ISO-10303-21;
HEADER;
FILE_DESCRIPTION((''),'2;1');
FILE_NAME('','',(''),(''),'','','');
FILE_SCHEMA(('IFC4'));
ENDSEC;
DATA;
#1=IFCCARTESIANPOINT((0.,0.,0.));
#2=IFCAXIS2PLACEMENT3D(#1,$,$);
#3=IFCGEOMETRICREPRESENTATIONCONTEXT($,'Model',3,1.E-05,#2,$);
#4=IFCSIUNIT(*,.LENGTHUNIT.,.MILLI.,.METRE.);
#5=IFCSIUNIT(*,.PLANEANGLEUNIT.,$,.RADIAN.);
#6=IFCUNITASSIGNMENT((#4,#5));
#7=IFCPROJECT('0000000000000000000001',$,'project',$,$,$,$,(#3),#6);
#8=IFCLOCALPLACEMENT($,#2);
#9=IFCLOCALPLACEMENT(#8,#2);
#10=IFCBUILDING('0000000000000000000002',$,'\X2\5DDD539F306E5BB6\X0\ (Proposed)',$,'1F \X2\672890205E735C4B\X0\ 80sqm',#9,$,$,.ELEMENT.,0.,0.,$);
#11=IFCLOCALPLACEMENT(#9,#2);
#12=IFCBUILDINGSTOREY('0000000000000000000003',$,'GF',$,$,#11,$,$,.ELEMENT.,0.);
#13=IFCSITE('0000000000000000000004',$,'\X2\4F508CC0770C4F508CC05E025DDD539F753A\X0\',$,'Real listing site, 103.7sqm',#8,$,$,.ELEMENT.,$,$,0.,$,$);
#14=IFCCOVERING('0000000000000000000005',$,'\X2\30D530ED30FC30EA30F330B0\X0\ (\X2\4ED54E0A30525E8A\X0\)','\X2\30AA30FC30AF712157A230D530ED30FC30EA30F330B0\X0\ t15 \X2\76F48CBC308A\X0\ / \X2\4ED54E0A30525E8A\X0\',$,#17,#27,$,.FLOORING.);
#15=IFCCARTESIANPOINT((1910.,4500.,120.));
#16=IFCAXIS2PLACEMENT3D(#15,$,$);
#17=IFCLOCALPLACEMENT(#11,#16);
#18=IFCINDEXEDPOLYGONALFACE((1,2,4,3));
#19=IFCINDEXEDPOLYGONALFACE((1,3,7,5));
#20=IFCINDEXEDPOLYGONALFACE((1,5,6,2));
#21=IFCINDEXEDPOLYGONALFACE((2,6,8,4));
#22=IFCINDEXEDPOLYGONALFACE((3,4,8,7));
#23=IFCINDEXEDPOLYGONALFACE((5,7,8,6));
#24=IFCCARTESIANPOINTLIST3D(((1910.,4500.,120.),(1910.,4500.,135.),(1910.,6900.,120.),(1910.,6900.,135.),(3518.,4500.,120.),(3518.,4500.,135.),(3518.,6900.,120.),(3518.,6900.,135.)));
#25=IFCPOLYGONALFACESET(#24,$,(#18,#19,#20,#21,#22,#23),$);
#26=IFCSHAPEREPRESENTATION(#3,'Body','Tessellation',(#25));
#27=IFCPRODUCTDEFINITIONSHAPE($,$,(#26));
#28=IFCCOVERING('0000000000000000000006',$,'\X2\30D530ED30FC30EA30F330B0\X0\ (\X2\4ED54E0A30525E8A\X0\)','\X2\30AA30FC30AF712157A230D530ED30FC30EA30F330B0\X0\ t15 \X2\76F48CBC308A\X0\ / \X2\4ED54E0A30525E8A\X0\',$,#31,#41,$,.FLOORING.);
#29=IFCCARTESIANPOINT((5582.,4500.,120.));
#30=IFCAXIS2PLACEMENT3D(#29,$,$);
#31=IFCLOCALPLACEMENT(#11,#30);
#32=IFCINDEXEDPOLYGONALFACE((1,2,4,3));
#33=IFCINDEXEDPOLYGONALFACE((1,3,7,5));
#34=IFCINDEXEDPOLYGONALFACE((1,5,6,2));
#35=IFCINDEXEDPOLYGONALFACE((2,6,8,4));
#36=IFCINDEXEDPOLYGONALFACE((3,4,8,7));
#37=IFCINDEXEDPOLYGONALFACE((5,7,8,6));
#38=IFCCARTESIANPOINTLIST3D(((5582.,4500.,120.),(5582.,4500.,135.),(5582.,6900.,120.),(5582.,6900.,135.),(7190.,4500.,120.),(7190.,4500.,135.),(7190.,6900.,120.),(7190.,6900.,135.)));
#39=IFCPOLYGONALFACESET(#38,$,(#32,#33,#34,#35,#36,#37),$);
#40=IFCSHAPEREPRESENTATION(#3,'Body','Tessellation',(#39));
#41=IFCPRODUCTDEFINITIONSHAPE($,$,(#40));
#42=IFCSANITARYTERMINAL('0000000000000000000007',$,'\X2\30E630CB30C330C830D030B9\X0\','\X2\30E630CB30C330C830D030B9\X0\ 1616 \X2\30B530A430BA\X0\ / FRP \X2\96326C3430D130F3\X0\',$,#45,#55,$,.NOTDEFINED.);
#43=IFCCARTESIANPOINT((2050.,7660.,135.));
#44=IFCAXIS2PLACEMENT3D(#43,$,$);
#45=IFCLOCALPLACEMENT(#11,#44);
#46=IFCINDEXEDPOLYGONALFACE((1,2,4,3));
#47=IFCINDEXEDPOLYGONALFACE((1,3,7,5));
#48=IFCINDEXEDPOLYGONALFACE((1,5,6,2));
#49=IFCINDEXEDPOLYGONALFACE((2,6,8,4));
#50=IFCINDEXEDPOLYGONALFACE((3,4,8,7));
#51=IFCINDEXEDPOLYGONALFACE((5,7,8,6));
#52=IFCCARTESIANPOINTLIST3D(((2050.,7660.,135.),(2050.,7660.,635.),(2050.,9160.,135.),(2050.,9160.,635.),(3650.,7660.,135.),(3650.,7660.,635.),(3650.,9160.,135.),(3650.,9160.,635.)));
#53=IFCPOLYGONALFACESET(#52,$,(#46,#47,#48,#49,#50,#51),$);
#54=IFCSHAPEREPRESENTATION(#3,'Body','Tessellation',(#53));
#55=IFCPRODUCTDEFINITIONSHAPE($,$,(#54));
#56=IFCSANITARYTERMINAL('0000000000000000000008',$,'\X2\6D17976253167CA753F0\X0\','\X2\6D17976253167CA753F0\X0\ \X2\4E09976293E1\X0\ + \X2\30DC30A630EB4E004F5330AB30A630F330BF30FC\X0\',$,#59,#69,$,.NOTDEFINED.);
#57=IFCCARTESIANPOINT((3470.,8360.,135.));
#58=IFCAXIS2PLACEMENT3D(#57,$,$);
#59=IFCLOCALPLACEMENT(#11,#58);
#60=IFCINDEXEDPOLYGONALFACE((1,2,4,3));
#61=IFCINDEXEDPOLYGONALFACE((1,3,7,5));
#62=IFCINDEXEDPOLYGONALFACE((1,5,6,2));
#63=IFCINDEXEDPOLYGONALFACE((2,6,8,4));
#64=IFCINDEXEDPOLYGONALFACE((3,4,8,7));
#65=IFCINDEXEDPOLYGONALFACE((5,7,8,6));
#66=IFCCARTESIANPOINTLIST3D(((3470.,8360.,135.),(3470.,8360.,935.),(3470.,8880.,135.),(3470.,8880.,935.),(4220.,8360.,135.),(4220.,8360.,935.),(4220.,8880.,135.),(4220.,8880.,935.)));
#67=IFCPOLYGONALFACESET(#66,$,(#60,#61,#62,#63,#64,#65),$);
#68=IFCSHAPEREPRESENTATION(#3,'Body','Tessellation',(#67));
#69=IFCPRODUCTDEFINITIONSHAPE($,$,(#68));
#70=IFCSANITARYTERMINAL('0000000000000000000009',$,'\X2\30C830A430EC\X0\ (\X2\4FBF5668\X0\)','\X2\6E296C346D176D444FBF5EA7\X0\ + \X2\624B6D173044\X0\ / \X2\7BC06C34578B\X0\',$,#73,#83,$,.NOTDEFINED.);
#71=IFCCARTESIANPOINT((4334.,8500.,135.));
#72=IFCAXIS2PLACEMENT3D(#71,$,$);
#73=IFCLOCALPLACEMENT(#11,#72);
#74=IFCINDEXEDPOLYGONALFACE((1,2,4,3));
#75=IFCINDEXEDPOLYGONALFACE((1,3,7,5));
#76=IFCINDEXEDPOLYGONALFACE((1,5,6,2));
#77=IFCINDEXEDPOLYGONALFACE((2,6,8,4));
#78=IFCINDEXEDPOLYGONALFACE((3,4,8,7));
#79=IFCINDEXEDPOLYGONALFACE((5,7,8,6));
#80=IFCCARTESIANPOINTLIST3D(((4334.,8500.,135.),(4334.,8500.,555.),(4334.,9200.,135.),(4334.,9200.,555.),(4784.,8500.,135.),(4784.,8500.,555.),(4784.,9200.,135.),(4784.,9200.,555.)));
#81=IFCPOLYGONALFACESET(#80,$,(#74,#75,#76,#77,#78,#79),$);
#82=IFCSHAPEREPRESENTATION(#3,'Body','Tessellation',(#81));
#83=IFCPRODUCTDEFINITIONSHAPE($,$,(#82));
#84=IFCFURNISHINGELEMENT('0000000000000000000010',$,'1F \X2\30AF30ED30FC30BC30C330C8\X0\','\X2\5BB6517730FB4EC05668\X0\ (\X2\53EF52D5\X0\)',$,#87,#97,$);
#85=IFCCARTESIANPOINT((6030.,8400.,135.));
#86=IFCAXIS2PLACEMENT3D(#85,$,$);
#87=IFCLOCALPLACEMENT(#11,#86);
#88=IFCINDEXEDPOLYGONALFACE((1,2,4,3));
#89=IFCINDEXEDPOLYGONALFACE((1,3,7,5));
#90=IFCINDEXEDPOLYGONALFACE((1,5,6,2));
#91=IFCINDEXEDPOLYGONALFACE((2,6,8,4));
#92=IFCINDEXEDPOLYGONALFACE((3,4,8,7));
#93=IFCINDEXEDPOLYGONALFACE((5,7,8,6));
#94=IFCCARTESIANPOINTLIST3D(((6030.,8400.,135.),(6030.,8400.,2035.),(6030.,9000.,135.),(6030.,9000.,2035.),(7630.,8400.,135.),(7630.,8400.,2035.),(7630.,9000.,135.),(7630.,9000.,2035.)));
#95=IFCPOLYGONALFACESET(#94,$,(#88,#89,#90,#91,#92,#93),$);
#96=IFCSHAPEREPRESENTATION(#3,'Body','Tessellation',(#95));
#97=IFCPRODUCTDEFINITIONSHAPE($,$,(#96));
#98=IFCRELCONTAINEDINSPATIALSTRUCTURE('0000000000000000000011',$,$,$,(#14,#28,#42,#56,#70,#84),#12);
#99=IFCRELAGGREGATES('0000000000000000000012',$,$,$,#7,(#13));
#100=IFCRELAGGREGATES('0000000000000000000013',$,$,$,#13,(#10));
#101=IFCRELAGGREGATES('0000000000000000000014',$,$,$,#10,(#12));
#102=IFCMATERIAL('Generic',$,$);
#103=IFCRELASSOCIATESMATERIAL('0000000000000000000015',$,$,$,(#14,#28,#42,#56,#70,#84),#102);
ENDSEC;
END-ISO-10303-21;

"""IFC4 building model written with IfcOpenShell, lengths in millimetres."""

from ifc_helpers import new_model, si_unit, frame, frame_2d, origin, place, context, project, spatial, rectangle, extrude, material, element, save


model = new_model("IFC4")

# Units and contexts
model_context = context("Model", 3, precision=1e-05, world=origin())
ifc_project = project(units=[si_unit("LENGTHUNIT", "METRE", prefix="MILLI"), si_unit("PLANEANGLEUNIT", "RADIAN")], contexts=[model_context])

# Site, building, storey
site_placement = place(None, origin())
site = spatial("IfcSite", under=ifc_project, at=site_placement, Name="佐賀県佐賀市川原町", ObjectType="Real listing site, 103.7sqm", CompositionType="ELEMENT", RefElevation=0.0)
building_placement = place(site_placement, origin())
building = spatial("IfcBuilding", under=site, at=building_placement, Name="川原の家 (Proposed)", ObjectType="1F 木造平屋 80sqm", CompositionType="ELEMENT", ElevationOfRefHeight=0.0, ElevationOfTerrain=0.0)
storey_placement = place(building_placement, origin())
storey = spatial("IfcBuildingStorey", under=building, at=storey_placement, Name="GF", CompositionType="ELEMENT", Elevation=0.0)

# Coverings
ifc_material_1 = material(Name="Generic")
covering_1_placement = place(storey_placement, frame((1910.0, 4500.0, 120.0)))
element("IfcCovering", 1, at=covering_1_placement, inside=storey, material=ifc_material_1, Name="フローリング (仕上げ床)", Description="オーク無垢フローリング t15 直貼り / 仕上げ床", PredefinedType="FLOORING", context=model_context, shape_type="SweptSolid", body=[
    extrude(rectangle(XDim=1608.0, YDim=2400.0, at=frame_2d((804.0, 1200.0))), frame((1910.0, 4500.0, 120.0)), (0.0, 0.0, 1.0), 15.0),
])
covering_2_placement = place(storey_placement, frame((5582.0, 4500.0, 120.0)))
element("IfcCovering", 2, at=covering_2_placement, inside=storey, material=ifc_material_1, Name="フローリング (仕上げ床)", Description="オーク無垢フローリング t15 直貼り / 仕上げ床", PredefinedType="FLOORING", context=model_context, shape_type="SweptSolid", body=[
    extrude(rectangle(XDim=1608.0, YDim=2400.0, at=frame_2d((804.0, 1200.0))), frame((5582.0, 4500.0, 120.0)), (0.0, 0.0, 1.0), 15.0),
])

# Sanitary terminals
sanitary_terminal_1_placement = place(storey_placement, frame((2050.0, 7660.0, 135.0)))
element("IfcSanitaryTerminal", 3, at=sanitary_terminal_1_placement, inside=storey, material=ifc_material_1, Name="ユニットバス", Description="ユニットバス 1616 サイズ / FRP 防水パン", PredefinedType="NOTDEFINED", context=model_context, shape_type="SweptSolid", body=[
    extrude(rectangle(XDim=1600.0, YDim=1500.0, at=frame_2d((800.0, 750.0))), frame((2050.0, 7660.0, 135.0)), (0.0, 0.0, 1.0), 500.0),
])
sanitary_terminal_2_placement = place(storey_placement, frame((3470.0, 8360.0, 135.0)))
element("IfcSanitaryTerminal", 4, at=sanitary_terminal_2_placement, inside=storey, material=ifc_material_1, Name="洗面化粧台", Description="洗面化粧台 三面鏡 + ボウル一体カウンター", PredefinedType="NOTDEFINED", context=model_context, shape_type="SweptSolid", body=[
    extrude(rectangle(XDim=750.0, YDim=520.0, at=frame_2d((375.0, 260.0))), frame((3470.0, 8360.0, 135.0)), (0.0, 0.0, 1.0), 800.0),
])
sanitary_terminal_3_placement = place(storey_placement, frame((4334.0, 8500.0, 135.0)))
element("IfcSanitaryTerminal", 5, at=sanitary_terminal_3_placement, inside=storey, material=ifc_material_1, Name="トイレ (便器)", Description="温水洗浄便座 + 手洗い / 節水型", PredefinedType="NOTDEFINED", context=model_context, shape_type="SweptSolid", body=[
    extrude(rectangle(XDim=450.0, YDim=700.0, at=frame_2d((225.0, 350.0))), frame((4334.0, 8500.0, 135.0)), (0.0, 0.0, 1.0), 420.0),
])

# Furnishing element
furnishing_placement = place(storey_placement, frame((6030.0, 8400.0, 135.0)))
element("IfcFurnishingElement", 6, at=furnishing_placement, inside=storey, material=ifc_material_1, Name="1F クローゼット", Description="家具・什器 (可動)", context=model_context, shape_type="SweptSolid", body=[
    extrude(rectangle(XDim=1600.0, YDim=600.0, at=frame_2d((800.0, 300.0))), frame((6030.0, 8400.0, 135.0)), (0.0, 0.0, 1.0), 1900.0),
])

save(model, "model.ifc")
